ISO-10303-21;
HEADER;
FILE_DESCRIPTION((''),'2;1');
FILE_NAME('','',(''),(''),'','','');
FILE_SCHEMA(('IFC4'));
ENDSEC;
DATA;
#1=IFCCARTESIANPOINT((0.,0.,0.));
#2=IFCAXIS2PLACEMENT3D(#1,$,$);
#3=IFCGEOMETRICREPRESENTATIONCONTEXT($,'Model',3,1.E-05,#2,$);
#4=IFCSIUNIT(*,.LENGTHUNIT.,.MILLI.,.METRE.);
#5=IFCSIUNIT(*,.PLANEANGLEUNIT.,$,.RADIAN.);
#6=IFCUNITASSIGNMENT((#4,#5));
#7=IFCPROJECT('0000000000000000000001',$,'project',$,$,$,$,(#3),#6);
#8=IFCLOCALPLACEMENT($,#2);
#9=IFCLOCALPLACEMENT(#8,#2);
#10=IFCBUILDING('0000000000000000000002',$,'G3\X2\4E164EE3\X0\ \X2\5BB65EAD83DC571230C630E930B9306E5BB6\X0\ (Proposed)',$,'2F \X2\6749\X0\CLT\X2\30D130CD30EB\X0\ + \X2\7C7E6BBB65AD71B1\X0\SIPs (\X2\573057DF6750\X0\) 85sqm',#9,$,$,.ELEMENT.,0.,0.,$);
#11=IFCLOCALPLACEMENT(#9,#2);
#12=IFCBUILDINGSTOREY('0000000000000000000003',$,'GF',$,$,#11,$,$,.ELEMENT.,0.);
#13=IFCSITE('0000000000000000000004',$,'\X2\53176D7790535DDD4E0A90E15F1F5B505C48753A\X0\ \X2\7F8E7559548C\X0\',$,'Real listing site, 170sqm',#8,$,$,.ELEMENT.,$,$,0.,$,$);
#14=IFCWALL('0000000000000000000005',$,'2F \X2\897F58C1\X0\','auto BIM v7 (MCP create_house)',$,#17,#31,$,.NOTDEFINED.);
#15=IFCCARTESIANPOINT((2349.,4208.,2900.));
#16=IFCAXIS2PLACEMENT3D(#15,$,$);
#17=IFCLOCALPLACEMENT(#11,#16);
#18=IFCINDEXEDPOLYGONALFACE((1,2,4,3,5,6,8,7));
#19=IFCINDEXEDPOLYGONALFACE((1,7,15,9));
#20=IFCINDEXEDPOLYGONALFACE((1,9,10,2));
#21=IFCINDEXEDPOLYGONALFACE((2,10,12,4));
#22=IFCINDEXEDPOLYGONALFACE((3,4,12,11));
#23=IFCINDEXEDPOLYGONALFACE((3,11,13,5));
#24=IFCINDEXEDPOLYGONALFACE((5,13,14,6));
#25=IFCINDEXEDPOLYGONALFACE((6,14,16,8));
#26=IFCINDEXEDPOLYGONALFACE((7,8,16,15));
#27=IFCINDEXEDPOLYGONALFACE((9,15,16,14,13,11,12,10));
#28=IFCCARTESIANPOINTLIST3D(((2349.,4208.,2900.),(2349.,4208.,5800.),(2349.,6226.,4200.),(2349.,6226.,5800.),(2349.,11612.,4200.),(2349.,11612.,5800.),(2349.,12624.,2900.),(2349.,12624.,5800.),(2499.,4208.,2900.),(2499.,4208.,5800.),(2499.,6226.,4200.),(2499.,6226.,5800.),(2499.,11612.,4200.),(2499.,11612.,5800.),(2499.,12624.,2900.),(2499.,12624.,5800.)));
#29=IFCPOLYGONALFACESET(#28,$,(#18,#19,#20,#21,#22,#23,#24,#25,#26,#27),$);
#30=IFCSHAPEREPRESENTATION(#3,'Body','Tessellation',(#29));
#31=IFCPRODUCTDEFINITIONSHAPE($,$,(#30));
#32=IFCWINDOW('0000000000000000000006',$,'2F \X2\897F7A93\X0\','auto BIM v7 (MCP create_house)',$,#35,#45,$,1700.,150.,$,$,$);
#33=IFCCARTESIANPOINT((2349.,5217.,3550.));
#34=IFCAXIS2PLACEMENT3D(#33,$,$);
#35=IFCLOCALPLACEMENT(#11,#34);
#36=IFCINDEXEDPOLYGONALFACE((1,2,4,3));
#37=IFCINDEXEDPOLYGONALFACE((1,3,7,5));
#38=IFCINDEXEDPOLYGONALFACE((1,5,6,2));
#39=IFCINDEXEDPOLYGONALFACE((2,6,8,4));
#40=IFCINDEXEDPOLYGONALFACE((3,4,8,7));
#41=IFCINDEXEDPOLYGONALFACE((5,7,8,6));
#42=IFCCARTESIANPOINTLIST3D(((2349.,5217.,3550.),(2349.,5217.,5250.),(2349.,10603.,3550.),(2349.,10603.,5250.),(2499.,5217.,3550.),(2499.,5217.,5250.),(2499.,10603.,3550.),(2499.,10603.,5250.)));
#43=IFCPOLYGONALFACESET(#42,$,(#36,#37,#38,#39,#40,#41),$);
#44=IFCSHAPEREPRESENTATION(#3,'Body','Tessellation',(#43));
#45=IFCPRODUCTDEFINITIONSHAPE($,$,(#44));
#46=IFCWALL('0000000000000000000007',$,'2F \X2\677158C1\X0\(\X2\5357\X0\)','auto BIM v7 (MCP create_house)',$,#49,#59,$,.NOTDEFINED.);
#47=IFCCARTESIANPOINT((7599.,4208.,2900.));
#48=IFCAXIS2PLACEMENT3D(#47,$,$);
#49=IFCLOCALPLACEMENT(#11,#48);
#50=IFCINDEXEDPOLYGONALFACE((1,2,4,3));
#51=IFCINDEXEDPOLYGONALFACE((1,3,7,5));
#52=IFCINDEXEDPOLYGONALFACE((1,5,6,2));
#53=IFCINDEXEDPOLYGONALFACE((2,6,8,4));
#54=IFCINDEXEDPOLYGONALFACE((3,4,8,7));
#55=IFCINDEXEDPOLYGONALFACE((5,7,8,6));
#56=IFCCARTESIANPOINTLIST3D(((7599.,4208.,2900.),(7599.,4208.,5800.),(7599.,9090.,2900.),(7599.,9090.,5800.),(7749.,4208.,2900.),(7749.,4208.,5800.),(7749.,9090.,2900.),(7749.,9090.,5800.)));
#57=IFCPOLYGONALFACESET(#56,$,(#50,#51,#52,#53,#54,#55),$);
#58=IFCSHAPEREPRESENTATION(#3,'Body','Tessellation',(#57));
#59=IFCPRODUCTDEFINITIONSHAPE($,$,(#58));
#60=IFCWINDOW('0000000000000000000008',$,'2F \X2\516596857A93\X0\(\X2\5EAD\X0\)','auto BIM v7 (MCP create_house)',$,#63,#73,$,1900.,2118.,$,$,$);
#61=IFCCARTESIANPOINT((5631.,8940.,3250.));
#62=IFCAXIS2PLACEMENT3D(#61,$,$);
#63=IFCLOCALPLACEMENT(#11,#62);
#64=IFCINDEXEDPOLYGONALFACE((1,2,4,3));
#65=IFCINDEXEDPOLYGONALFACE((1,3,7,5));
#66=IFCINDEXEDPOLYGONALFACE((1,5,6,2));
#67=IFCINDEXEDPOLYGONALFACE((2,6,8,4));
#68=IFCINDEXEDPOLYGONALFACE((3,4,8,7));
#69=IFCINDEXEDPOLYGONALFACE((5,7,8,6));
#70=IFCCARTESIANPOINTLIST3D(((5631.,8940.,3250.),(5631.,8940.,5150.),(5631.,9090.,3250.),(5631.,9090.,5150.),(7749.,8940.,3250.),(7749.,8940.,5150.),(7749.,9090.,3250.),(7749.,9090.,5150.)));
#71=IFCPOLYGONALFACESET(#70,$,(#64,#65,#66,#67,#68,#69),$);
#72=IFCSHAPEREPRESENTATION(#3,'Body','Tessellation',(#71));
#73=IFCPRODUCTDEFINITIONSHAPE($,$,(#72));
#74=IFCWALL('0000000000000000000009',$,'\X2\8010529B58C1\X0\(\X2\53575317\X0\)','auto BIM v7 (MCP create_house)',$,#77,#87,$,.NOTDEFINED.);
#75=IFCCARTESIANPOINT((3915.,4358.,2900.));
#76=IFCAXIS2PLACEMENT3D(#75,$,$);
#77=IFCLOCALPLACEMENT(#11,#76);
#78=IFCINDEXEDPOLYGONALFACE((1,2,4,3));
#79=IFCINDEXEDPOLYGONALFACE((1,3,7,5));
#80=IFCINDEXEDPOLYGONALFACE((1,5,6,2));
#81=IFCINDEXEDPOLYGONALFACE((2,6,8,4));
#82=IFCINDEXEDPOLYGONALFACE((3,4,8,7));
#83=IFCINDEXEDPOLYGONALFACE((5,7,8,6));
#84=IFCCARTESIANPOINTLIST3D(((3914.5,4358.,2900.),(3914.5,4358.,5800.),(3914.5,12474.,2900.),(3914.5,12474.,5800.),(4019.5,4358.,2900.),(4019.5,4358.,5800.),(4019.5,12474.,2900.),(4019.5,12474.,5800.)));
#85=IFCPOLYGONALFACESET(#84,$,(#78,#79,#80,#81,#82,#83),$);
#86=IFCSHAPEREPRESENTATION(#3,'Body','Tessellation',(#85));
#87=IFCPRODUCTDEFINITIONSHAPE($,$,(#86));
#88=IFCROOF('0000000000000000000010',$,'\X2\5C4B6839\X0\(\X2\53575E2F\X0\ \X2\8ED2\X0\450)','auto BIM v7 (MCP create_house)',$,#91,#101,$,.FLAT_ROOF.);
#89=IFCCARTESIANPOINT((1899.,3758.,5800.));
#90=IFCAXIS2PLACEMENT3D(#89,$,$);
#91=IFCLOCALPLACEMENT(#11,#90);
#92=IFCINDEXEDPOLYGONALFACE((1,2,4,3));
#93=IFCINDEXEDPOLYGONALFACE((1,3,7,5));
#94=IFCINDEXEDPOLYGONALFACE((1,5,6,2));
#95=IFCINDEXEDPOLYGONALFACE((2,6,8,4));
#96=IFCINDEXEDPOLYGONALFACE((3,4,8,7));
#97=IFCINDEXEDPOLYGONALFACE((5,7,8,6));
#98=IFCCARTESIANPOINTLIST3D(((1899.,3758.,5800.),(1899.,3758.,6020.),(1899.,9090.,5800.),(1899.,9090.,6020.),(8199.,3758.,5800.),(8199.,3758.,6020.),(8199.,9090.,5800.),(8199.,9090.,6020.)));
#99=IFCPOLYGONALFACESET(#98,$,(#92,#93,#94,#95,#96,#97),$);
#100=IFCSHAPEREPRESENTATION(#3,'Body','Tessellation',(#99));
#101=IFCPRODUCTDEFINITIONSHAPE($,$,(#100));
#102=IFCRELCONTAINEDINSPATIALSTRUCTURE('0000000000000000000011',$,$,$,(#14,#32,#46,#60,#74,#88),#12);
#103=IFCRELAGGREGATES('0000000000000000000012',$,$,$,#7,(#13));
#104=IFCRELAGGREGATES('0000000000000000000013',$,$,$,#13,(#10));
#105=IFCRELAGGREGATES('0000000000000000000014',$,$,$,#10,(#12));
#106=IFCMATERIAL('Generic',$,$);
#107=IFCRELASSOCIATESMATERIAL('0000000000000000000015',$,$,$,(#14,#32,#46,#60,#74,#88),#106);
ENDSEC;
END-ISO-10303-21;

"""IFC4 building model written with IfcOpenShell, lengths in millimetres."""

from ifc_helpers import new_model, si_unit, frame, frame_2d, origin, place, context, project, spatial, rectangle, extrude, material, element, fill, save


model = new_model("IFC4")

# Units and contexts
model_context = context("Model", 3, precision=1e-05, world=origin())
ifc_project = project(units=[si_unit("LENGTHUNIT", "METRE", prefix="MILLI"), si_unit("PLANEANGLEUNIT", "RADIAN")], contexts=[model_context])

# Site, building, storey
site_placement = place(None, origin())
site = spatial("IfcSite", under=ifc_project, at=site_placement, Name="北海道川上郡弟子屈町 美留和", ObjectType="Real listing site, 170sqm", CompositionType="ELEMENT", RefElevation=0.0)
building_placement = place(site_placement, origin())
building = spatial("IfcBuilding", under=site, at=building_placement, Name="G3世代 家庭菜園テラスの家 (Proposed)", ObjectType="2F 杉CLTパネル + 籾殻断熱SIPs (地域材) 85sqm", CompositionType="ELEMENT", ElevationOfRefHeight=0.0, ElevationOfTerrain=0.0)
storey_placement = place(building_placement, origin())
storey = spatial("IfcBuildingStorey", under=building, at=storey_placement, Name="GF", CompositionType="ELEMENT", Elevation=0.0)

# Shared definitions
ifc_material = material(Name="Generic")

# Walls, openings, windows
wall_1_placement = place(storey_placement, frame((2349.0, 4208.0, 2900.0)))
wall_1 = element("IfcWall", 1, at=wall_1_placement, inside=storey, material=ifc_material, Name="2F 西壁", Description="auto BIM v7 (MCP create_house)", PredefinedType="NOTDEFINED", context=model_context, shape_type="SweptSolid", body=[
    extrude(rectangle(XDim=150.0, YDim=8416.0, at=frame_2d((75.0, 4208.0))), frame((2349.0, 4208.0, 2900.0)), (0.0, 0.0, 1.0), 2900.0),
])
opening_1_placement = place(storey_placement, frame((2349.0, 5217.0, 3550.0)))
opening_1 = element("IfcOpeningElement", 2, at=opening_1_placement, cuts=wall_1, PredefinedType="NOTDEFINED", context=model_context, shape_type="SweptSolid", body=[
    extrude(rectangle(XDim=150.0, YDim=5386.0, at=frame_2d((75.0, 2693.0))), frame((2349.0, 5217.0, 3550.0)), (0.0, 0.0, 1.0), 1700.0),
])
window_1_placement = place(storey_placement, frame((2349.0, 5217.0, 3550.0)))
window_1 = element("IfcWindow", 3, at=window_1_placement, inside=storey, material=ifc_material, Name="2F 西窓", Description="auto BIM v7 (MCP create_house)", OverallHeight=1700.0, OverallWidth=150.0, context=model_context, shape_type="SweptSolid", body=[
    extrude(rectangle(XDim=150.0, YDim=5386.0, at=frame_2d((75.0, 2693.0))), frame((2349.0, 5217.0, 3550.0)), (0.0, 0.0, 1.0), 1700.0),
])
fill(opening_1, window_1)
wall_2_placement = place(storey_placement, frame((7599.0, 4208.0, 2900.0)))
wall_2 = element("IfcWall", 4, at=wall_2_placement, inside=storey, material=ifc_material, Name="2F 東壁(南)", Description="auto BIM v7 (MCP create_house)", PredefinedType="NOTDEFINED", context=model_context, shape_type="SweptSolid", body=[
    extrude(rectangle(XDim=150.0, YDim=4882.0, at=frame_2d((75.0, 2441.0))), frame((7599.0, 4208.0, 2900.0)), (0.0, 0.0, 1.0), 2900.0),
])
opening_2_placement = place(storey_placement, frame((5631.0, 8940.0, 3250.0)))
opening_2 = element("IfcOpeningElement", 5, at=opening_2_placement, cuts=wall_2, PredefinedType="NOTDEFINED", context=model_context, shape_type="SweptSolid", body=[
    extrude(rectangle(XDim=2118.0, YDim=150.0, at=frame_2d((1059.0, 75.0))), frame((5631.0, 8940.0, 3250.0)), (0.0, 0.0, 1.0), 1900.0),
])
window_2_placement = place(storey_placement, frame((5631.0, 8940.0, 3250.0)))
window_2 = element("IfcWindow", 6, at=window_2_placement, inside=storey, material=ifc_material, Name="2F 入隅窓(庭)", Description="auto BIM v7 (MCP create_house)", OverallHeight=1900.0, OverallWidth=2118.0, context=model_context, shape_type="SweptSolid", body=[
    extrude(rectangle(XDim=2118.0, YDim=150.0, at=frame_2d((1059.0, 75.0))), frame((5631.0, 8940.0, 3250.0)), (0.0, 0.0, 1.0), 1900.0),
])
fill(opening_2, window_2)

# Wall
wall_3_placement = place(storey_placement, frame((3915.0, 4358.0, 2900.0)))
element("IfcWall", 7, at=wall_3_placement, inside=storey, material=ifc_material, Name="耐力壁(南北)", Description="auto BIM v7 (MCP create_house)", PredefinedType="NOTDEFINED", context=model_context, shape_type="SweptSolid", body=[
    extrude(rectangle(XDim=105.0, YDim=8116.0, at=frame_2d((52.0, 4058.0))), frame((3915.0, 4358.0, 2900.0)), (0.0, 0.0, 1.0), 2900.0),
])

# Roof
for number, where, name in (
    (8, (1899.0, 3758.0, 5800.0), "屋根(南帯 軒450)"),
):
    element("IfcRoof", number, at=place(storey_placement, frame(where)), inside=storey, material=ifc_material, Name=name, Description="auto BIM v7 (MCP create_house)", PredefinedType="FLAT_ROOF", context=model_context, shape_type="SweptSolid", body=[
        extrude(rectangle(XDim=6300.0, YDim=5332.0, at=frame_2d((3150.0, 2666.0))), frame((1899.0, 3758.0, 5800.0)), (0.0, 0.0, 1.0), 220.0),
    ])

save(model, "model.ifc")
